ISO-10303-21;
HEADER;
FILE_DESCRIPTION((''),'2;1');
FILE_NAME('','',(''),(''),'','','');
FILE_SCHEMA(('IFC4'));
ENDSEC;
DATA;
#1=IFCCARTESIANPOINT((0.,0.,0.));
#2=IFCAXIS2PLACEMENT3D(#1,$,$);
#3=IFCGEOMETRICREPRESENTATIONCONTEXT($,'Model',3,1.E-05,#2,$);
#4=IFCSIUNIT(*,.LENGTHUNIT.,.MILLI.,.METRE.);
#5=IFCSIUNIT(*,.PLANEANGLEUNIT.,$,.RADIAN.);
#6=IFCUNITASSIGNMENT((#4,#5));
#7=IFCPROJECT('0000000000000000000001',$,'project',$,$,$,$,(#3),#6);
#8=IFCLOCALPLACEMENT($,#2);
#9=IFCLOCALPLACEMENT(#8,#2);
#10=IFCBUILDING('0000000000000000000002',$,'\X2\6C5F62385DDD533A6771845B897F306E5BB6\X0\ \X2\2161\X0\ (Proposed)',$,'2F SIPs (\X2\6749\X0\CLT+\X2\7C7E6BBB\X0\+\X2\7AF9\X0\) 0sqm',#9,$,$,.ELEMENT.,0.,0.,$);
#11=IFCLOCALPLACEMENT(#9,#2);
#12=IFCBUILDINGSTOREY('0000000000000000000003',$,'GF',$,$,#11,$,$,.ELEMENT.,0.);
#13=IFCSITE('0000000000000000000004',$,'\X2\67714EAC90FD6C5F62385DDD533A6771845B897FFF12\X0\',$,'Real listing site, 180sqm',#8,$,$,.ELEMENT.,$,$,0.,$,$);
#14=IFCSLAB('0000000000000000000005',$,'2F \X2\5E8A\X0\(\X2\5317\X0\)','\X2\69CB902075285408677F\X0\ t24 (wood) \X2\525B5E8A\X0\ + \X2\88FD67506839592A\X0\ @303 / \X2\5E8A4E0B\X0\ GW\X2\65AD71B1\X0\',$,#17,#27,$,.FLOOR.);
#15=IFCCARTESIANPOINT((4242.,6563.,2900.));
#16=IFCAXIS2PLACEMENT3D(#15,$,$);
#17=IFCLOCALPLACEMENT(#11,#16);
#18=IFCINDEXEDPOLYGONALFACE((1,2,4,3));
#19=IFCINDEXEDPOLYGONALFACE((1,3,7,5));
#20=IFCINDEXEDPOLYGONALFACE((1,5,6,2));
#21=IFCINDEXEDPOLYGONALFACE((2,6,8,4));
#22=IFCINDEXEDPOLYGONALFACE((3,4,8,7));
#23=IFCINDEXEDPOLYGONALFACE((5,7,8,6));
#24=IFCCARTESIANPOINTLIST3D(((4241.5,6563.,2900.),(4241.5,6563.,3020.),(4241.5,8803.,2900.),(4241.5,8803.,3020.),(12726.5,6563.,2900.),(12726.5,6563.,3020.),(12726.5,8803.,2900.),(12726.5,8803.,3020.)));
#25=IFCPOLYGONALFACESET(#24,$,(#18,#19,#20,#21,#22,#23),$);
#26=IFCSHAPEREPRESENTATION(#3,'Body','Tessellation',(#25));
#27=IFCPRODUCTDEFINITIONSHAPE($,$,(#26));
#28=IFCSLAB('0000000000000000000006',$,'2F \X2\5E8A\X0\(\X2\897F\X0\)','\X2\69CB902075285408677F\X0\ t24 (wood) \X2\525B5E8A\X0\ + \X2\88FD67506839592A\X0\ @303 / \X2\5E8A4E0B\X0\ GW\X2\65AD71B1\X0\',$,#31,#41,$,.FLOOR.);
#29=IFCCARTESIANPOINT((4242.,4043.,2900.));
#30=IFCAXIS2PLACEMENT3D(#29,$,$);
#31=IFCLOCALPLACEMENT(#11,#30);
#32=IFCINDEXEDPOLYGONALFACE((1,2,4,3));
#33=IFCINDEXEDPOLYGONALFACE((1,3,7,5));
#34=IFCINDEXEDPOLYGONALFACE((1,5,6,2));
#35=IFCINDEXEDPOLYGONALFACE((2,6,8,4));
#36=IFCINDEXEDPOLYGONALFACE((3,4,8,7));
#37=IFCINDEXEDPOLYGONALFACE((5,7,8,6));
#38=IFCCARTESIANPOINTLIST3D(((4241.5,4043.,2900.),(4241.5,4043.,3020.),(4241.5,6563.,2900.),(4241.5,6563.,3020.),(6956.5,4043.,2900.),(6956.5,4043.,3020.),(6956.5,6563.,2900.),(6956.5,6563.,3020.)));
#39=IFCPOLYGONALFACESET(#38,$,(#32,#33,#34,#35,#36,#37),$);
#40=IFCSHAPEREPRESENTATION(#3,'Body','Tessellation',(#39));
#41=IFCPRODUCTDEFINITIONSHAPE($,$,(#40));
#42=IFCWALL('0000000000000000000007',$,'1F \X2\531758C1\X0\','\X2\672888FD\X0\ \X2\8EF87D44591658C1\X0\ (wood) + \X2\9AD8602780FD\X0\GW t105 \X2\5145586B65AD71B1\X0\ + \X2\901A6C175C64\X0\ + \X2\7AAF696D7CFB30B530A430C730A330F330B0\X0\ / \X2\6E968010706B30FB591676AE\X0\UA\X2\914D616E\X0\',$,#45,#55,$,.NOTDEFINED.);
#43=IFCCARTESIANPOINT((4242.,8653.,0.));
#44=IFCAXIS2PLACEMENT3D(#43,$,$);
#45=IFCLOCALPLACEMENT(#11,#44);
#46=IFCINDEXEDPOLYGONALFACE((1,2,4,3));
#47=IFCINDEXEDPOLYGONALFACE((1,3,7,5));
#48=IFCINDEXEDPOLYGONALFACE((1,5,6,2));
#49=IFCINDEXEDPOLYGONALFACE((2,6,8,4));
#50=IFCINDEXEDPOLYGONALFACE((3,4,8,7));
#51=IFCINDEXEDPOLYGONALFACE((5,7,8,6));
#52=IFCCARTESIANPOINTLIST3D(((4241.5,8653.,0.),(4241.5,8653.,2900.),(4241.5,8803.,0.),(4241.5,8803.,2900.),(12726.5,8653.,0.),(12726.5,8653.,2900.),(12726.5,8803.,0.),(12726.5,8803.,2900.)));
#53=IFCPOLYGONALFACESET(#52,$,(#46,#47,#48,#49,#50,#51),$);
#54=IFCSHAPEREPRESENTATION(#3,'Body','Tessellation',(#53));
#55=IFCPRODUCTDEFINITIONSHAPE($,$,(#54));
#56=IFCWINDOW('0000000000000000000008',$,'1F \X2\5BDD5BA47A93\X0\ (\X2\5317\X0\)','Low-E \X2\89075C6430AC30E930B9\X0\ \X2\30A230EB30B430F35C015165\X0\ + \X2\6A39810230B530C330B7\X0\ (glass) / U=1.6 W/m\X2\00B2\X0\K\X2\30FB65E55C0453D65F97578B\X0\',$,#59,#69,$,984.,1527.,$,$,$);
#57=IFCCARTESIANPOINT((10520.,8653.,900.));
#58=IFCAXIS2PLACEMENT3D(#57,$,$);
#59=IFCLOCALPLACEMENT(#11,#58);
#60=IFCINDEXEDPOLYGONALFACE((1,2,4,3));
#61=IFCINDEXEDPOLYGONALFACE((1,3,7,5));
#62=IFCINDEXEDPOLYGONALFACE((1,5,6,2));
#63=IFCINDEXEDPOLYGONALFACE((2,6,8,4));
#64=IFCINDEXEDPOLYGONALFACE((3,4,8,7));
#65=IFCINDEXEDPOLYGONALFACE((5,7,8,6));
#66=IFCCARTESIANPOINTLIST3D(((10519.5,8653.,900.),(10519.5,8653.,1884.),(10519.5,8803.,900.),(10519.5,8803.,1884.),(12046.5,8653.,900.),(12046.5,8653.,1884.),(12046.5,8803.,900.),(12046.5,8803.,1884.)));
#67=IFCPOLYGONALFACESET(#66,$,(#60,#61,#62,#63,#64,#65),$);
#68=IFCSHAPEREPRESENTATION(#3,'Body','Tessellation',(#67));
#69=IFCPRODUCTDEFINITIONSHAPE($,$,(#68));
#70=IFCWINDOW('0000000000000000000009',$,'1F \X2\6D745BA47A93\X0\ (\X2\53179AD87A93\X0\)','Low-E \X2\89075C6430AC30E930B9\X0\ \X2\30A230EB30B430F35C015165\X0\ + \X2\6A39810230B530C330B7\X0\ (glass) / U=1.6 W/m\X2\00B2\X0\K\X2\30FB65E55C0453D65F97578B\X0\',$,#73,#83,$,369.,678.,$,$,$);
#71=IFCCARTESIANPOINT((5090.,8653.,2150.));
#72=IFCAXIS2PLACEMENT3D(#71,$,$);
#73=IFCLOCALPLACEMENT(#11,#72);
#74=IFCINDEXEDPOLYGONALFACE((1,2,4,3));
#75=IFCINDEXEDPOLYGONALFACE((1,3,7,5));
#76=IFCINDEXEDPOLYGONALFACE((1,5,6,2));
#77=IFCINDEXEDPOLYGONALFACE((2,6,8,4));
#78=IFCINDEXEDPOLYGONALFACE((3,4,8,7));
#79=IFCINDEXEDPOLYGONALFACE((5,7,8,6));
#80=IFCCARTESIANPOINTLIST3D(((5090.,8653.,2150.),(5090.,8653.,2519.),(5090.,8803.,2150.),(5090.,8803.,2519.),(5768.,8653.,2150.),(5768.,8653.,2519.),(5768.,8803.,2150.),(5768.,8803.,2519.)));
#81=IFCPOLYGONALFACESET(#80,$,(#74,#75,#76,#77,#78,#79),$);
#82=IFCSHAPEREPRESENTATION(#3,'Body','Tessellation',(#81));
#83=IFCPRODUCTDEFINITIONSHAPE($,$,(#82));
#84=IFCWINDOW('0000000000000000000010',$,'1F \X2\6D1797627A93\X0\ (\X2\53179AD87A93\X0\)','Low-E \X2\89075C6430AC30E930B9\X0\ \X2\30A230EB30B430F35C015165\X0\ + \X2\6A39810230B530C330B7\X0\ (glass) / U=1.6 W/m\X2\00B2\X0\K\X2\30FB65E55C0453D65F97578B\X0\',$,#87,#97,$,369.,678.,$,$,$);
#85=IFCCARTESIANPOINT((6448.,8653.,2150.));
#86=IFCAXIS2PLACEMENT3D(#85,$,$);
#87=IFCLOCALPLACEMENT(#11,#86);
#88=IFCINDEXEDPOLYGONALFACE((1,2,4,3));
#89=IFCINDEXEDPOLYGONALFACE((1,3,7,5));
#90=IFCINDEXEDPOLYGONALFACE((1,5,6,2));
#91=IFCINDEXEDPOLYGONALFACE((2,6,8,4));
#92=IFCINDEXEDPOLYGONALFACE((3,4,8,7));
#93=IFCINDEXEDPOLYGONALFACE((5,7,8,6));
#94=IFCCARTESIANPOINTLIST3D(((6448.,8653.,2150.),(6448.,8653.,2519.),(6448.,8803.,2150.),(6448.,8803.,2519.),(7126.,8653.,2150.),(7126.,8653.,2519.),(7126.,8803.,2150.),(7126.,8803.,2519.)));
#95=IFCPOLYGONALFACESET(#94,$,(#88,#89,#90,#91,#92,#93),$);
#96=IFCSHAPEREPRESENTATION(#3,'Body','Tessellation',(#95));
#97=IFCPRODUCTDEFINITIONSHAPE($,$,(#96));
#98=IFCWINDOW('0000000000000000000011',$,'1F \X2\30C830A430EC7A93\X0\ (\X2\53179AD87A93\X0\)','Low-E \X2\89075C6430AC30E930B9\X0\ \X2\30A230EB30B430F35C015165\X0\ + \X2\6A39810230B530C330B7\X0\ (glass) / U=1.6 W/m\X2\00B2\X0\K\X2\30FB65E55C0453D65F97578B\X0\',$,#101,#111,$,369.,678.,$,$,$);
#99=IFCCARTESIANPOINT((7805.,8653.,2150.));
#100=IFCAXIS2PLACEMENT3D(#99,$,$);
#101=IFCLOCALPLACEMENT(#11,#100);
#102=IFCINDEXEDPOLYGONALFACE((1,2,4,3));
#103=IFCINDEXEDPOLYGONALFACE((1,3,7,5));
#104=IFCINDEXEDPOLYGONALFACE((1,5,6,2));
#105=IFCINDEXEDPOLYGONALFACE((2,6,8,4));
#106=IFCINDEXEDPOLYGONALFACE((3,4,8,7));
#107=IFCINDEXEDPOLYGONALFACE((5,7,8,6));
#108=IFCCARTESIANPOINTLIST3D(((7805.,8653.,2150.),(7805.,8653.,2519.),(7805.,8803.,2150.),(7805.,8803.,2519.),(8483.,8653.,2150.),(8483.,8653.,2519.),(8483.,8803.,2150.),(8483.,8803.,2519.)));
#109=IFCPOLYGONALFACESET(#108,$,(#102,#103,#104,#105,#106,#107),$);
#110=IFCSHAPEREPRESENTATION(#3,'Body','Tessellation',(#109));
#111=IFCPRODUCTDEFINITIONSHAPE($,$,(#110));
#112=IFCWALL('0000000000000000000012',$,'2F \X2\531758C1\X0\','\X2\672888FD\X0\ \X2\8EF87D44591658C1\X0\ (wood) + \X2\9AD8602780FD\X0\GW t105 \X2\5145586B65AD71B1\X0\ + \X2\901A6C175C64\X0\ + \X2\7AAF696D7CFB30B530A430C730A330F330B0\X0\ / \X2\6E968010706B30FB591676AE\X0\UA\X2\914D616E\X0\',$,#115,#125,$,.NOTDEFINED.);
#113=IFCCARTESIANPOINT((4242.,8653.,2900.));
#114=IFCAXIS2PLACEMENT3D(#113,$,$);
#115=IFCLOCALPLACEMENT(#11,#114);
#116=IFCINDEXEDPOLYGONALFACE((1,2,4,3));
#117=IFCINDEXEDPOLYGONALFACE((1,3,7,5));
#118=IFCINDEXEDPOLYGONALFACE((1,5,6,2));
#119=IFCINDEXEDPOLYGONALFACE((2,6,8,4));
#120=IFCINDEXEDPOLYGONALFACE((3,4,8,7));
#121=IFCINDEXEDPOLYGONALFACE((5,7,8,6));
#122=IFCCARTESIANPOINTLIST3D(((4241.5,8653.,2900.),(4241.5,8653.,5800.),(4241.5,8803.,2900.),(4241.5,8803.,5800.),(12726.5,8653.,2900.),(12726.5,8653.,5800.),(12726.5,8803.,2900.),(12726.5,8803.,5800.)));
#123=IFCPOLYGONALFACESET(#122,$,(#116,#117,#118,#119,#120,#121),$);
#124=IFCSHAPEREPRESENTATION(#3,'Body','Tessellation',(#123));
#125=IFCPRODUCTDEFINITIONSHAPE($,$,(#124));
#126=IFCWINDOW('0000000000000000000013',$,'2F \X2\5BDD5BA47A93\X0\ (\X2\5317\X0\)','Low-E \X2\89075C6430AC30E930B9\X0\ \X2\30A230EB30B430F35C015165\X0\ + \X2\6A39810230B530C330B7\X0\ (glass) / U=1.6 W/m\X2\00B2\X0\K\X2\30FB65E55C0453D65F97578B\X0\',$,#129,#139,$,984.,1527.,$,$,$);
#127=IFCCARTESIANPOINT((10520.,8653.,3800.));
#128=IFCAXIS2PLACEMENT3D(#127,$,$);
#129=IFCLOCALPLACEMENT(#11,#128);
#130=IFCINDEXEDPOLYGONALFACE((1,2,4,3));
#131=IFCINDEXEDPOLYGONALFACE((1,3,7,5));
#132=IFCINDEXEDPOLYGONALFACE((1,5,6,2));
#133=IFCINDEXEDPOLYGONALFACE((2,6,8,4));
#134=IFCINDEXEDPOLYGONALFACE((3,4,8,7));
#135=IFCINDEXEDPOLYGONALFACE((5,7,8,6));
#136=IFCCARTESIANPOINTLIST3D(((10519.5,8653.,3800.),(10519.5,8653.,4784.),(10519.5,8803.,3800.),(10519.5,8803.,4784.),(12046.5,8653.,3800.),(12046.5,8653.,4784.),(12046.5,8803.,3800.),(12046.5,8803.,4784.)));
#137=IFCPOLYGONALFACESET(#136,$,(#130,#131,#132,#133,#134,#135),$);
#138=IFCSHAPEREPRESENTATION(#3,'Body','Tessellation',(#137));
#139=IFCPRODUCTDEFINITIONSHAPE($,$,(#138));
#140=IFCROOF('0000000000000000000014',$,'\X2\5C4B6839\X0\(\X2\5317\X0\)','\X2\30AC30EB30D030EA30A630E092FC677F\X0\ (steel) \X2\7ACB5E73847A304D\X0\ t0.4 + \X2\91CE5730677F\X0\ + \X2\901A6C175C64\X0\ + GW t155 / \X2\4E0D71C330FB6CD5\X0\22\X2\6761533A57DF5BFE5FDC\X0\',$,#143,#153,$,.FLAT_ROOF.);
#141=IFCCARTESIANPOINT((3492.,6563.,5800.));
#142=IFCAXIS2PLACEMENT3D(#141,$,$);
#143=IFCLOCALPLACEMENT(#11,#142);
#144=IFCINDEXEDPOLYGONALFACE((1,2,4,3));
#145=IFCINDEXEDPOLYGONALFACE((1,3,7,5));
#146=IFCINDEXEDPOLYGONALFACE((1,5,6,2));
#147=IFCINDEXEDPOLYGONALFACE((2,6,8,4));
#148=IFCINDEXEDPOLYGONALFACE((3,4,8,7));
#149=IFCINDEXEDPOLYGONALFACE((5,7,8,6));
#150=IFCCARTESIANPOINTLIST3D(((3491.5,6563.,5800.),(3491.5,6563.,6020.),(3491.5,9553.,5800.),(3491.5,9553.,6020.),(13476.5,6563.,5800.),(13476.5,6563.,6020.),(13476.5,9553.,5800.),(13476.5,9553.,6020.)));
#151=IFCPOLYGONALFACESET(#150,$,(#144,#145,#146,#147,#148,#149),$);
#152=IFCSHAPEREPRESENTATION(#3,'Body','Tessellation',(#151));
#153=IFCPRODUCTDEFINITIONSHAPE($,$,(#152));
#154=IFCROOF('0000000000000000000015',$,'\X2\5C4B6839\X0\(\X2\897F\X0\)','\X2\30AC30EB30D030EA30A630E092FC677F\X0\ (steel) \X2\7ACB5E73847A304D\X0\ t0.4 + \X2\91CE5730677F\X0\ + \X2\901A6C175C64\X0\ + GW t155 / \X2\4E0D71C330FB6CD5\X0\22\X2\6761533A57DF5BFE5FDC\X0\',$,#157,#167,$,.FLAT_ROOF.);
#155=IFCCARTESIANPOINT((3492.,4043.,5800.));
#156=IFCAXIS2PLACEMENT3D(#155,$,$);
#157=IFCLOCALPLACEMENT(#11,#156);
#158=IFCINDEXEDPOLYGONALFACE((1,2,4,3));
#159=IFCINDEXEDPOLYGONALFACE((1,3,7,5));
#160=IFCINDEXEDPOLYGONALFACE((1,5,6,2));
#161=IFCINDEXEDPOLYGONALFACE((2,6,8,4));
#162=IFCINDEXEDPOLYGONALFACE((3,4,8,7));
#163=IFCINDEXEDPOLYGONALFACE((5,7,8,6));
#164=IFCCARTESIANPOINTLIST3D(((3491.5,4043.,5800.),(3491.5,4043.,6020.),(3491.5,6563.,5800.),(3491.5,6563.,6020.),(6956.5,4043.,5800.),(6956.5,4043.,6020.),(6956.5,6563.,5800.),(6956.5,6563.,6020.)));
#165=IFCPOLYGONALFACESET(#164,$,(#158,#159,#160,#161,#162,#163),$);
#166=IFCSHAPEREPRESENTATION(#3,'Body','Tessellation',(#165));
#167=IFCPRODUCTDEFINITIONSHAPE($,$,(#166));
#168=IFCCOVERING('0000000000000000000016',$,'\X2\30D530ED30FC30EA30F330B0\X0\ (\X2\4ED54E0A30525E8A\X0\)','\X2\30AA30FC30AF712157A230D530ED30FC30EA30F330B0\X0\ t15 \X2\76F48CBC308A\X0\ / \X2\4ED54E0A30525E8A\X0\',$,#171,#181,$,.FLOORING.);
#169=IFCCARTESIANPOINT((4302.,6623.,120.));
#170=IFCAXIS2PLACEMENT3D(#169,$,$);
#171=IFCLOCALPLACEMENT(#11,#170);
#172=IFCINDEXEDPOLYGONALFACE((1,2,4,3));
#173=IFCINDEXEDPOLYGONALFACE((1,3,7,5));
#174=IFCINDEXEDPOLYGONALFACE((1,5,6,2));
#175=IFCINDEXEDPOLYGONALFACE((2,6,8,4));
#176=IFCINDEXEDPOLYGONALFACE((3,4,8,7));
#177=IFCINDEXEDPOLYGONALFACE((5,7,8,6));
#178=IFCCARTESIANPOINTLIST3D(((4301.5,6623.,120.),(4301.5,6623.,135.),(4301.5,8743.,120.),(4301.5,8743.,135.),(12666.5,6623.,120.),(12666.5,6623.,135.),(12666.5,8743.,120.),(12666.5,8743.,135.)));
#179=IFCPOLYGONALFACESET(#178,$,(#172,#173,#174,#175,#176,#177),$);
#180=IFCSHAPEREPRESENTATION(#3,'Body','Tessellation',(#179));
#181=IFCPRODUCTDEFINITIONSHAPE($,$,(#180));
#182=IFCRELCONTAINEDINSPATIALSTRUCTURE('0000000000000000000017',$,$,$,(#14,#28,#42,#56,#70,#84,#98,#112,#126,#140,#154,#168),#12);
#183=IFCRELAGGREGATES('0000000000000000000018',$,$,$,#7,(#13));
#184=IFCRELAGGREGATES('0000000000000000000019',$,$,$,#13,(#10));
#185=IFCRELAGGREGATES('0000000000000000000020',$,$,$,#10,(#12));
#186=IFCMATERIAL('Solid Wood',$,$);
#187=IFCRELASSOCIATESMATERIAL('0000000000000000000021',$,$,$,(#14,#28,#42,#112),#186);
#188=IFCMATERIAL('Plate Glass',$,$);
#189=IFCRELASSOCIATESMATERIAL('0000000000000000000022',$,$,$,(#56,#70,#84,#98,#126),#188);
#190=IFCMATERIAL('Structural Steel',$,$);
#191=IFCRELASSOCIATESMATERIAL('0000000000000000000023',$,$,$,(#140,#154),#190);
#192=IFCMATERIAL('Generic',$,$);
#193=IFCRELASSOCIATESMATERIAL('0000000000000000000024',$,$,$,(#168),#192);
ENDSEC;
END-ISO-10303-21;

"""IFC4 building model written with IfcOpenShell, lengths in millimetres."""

from ifc_helpers import new_model, si_unit, frame, frame_2d, origin, place, context, project, spatial, rectangle, extrude, material, element, fill, save


model = new_model("IFC4")

# Units and contexts
model_context = context("Model", 3, precision=1e-05, world=origin())
ifc_project = project(units=[si_unit("LENGTHUNIT", "METRE", prefix="MILLI"), si_unit("PLANEANGLEUNIT", "RADIAN")], contexts=[model_context])

# Site, building, storey
site_placement = place(None, origin())
site = spatial("IfcSite", under=ifc_project, at=site_placement, Name="東京都江戸川区東葛西２", ObjectType="Real listing site, 180sqm", CompositionType="ELEMENT", RefElevation=0.0)
building_placement = place(site_placement, origin())
building = spatial("IfcBuilding", under=site, at=building_placement, Name="江戸川区東葛西の家 Ⅱ (Proposed)", ObjectType="2F SIPs (杉CLT+籾殻+竹) 0sqm", CompositionType="ELEMENT", ElevationOfRefHeight=0.0, ElevationOfTerrain=0.0)
storey_placement = place(building_placement, origin())
storey = spatial("IfcBuildingStorey", under=building, at=storey_placement, Name="GF", CompositionType="ELEMENT", Elevation=0.0)

# Slabs
ifc_material_1 = material(Name="Solid Wood")
slab_1_placement = place(storey_placement, frame((4242.0, 6563.0, 2900.0)))
element("IfcSlab", 1, at=slab_1_placement, inside=storey, material=ifc_material_1, Name="2F 床(北)", Description="構造用合板 t24 (wood) 剛床 + 製材根太 @303 / 床下 GW断熱", PredefinedType="FLOOR", context=model_context, shape_type="SweptSolid", body=[
    extrude(rectangle(XDim=8485.0, YDim=2240.0, at=frame_2d((4242.0, 1120.0))), frame((4242.0, 6563.0, 2900.0)), (0.0, 0.0, 1.0), 120.0),
])
slab_2_placement = place(storey_placement, frame((4242.0, 4043.0, 2900.0)))
element("IfcSlab", 2, at=slab_2_placement, inside=storey, material=ifc_material_1, Name="2F 床(西)", Description="構造用合板 t24 (wood) 剛床 + 製材根太 @303 / 床下 GW断熱", PredefinedType="FLOOR", context=model_context, shape_type="SweptSolid", body=[
    extrude(rectangle(XDim=2715.0, YDim=2520.0, at=frame_2d((1357.0, 1260.0))), frame((4242.0, 4043.0, 2900.0)), (0.0, 0.0, 1.0), 120.0),
])

# Wall, openings, windows
wall_1_placement = place(storey_placement, frame((4242.0, 8653.0, 0.0)))
wall_1 = element("IfcWall", 3, at=wall_1_placement, inside=storey, material=ifc_material_1, Name="1F 北壁", Description="木製 軸組外壁 (wood) + 高性能GW t105 充填断熱 + 通気層 + 窯業系サイディング / 準耐火・外皮UA配慮", PredefinedType="NOTDEFINED", context=model_context, shape_type="SweptSolid", body=[
    extrude(rectangle(XDim=8485.0, YDim=150.0, at=frame_2d((4242.0, 75.0))), frame((4242.0, 8653.0, 0.0)), (0.0, 0.0, 1.0), 2900.0),
])
opening_1_placement = place(storey_placement, frame((10520.0, 8653.0, 900.0)))
opening_1 = element("IfcOpeningElement", 4, at=opening_1_placement, cuts=wall_1, PredefinedType="NOTDEFINED", context=model_context, shape_type="SweptSolid", body=[
    extrude(rectangle(XDim=1527.0, YDim=150.0, at=frame_2d((763.0, 75.0))), frame((10520.0, 8653.0, 900.0)), (0.0, 0.0, 1.0), 984.0),
])
opening_2_placement = place(storey_placement, frame((5090.0, 8653.0, 2150.0)))
opening_2 = element("IfcOpeningElement", 5, at=opening_2_placement, cuts=wall_1, PredefinedType="NOTDEFINED", context=model_context, shape_type="SweptSolid", body=[
    extrude(rectangle(XDim=678.0, YDim=150.0, at=frame_2d((339.0, 75.0))), frame((5090.0, 8653.0, 2150.0)), (0.0, 0.0, 1.0), 369.0),
])
opening_3_placement = place(storey_placement, frame((6448.0, 8653.0, 2150.0)))
opening_3 = element("IfcOpeningElement", 6, at=opening_3_placement, cuts=wall_1, PredefinedType="NOTDEFINED", context=model_context, shape_type="SweptSolid", body=[
    extrude(rectangle(XDim=678.0, YDim=150.0, at=frame_2d((339.0, 75.0))), frame((6448.0, 8653.0, 2150.0)), (0.0, 0.0, 1.0), 369.0),
])
opening_4_placement = place(storey_placement, frame((7805.0, 8653.0, 2150.0)))
opening_4 = element("IfcOpeningElement", 7, at=opening_4_placement, cuts=wall_1, PredefinedType="NOTDEFINED", context=model_context, shape_type="SweptSolid", body=[
    extrude(rectangle(XDim=678.0, YDim=150.0, at=frame_2d((339.0, 75.0))), frame((7805.0, 8653.0, 2150.0)), (0.0, 0.0, 1.0), 369.0),
])
ifc_material_2 = material(Name="Plate Glass")
window_1_placement = place(storey_placement, frame((10520.0, 8653.0, 900.0)))
window_1 = element("IfcWindow", 8, at=window_1_placement, inside=storey, material=ifc_material_2, Name="1F 寝室窓 (北)", Description="Low-E 複層ガラス アルゴン封入 + 樹脂サッシ (glass) / U=1.6 W/m²K・日射取得型", OverallHeight=984.0, OverallWidth=1527.0, context=model_context, shape_type="SweptSolid", body=[
    extrude(rectangle(XDim=1527.0, YDim=150.0, at=frame_2d((763.0, 75.0))), frame((10520.0, 8653.0, 900.0)), (0.0, 0.0, 1.0), 984.0),
])
fill(opening_1, window_1)
window_2_placement = place(storey_placement, frame((5090.0, 8653.0, 2150.0)))
window_2 = element("IfcWindow", 9, at=window_2_placement, inside=storey, material=ifc_material_2, Name="1F 浴室窓 (北高窓)", Description="Low-E 複層ガラス アルゴン封入 + 樹脂サッシ (glass) / U=1.6 W/m²K・日射取得型", OverallHeight=369.0, OverallWidth=678.0, context=model_context, shape_type="SweptSolid", body=[
    extrude(rectangle(XDim=678.0, YDim=150.0, at=frame_2d((339.0, 75.0))), frame((5090.0, 8653.0, 2150.0)), (0.0, 0.0, 1.0), 369.0),
])
fill(opening_2, window_2)
window_3_placement = place(storey_placement, frame((6448.0, 8653.0, 2150.0)))
window_3 = element("IfcWindow", 10, at=window_3_placement, inside=storey, material=ifc_material_2, Name="1F 洗面窓 (北高窓)", Description="Low-E 複層ガラス アルゴン封入 + 樹脂サッシ (glass) / U=1.6 W/m²K・日射取得型", OverallHeight=369.0, OverallWidth=678.0, context=model_context, shape_type="SweptSolid", body=[
    extrude(rectangle(XDim=678.0, YDim=150.0, at=frame_2d((339.0, 75.0))), frame((6448.0, 8653.0, 2150.0)), (0.0, 0.0, 1.0), 369.0),
])
fill(opening_3, window_3)
window_4_placement = place(storey_placement, frame((7805.0, 8653.0, 2150.0)))
window_4 = element("IfcWindow", 11, at=window_4_placement, inside=storey, material=ifc_material_2, Name="1F トイレ窓 (北高窓)", Description="Low-E 複層ガラス アルゴン封入 + 樹脂サッシ (glass) / U=1.6 W/m²K・日射取得型", OverallHeight=369.0, OverallWidth=678.0, context=model_context, shape_type="SweptSolid", body=[
    extrude(rectangle(XDim=678.0, YDim=150.0, at=frame_2d((339.0, 75.0))), frame((7805.0, 8653.0, 2150.0)), (0.0, 0.0, 1.0), 369.0),
])
fill(opening_4, window_4)

# Wall, opening, window
wall_2_placement = place(storey_placement, frame((4242.0, 8653.0, 2900.0)))
wall_2 = element("IfcWall", 12, at=wall_2_placement, inside=storey, material=ifc_material_1, Name="2F 北壁", Description="木製 軸組外壁 (wood) + 高性能GW t105 充填断熱 + 通気層 + 窯業系サイディング / 準耐火・外皮UA配慮", PredefinedType="NOTDEFINED", context=model_context, shape_type="SweptSolid", body=[
    extrude(rectangle(XDim=8485.0, YDim=150.0, at=frame_2d((4242.0, 75.0))), frame((4242.0, 8653.0, 2900.0)), (0.0, 0.0, 1.0), 2900.0),
])
opening_5_placement = place(storey_placement, frame((10520.0, 8653.0, 3800.0)))
opening_5 = element("IfcOpeningElement", 13, at=opening_5_placement, cuts=wall_2, PredefinedType="NOTDEFINED", context=model_context, shape_type="SweptSolid", body=[
    extrude(rectangle(XDim=1527.0, YDim=150.0, at=frame_2d((763.0, 75.0))), frame((10520.0, 8653.0, 3800.0)), (0.0, 0.0, 1.0), 984.0),
])
window_5_placement = place(storey_placement, frame((10520.0, 8653.0, 3800.0)))
window_5 = element("IfcWindow", 14, at=window_5_placement, inside=storey, material=ifc_material_2, Name="2F 寝室窓 (北)", Description="Low-E 複層ガラス アルゴン封入 + 樹脂サッシ (glass) / U=1.6 W/m²K・日射取得型", OverallHeight=984.0, OverallWidth=1527.0, context=model_context, shape_type="SweptSolid", body=[
    extrude(rectangle(XDim=1527.0, YDim=150.0, at=frame_2d((763.0, 75.0))), frame((10520.0, 8653.0, 3800.0)), (0.0, 0.0, 1.0), 984.0),
])
fill(opening_5, window_5)

# Roofs
ifc_material_3 = material(Name="Structural Steel")
for number, where, name in (
    (15, (3492.0, 6563.0, 5800.0), "屋根(北)"),
):
    element("IfcRoof", number, at=place(storey_placement, frame(where)), inside=storey, material=ifc_material_3, Name=name, Description="ガルバリウム鋼板 (steel) 立平葺き t0.4 + 野地板 + 通気層 + GW t155 / 不燃・法22条区域対応", PredefinedType="FLAT_ROOF", context=model_context, shape_type="SweptSolid", body=[
        extrude(rectangle(XDim=9985.0, YDim=2990.0, at=frame_2d((4992.0, 1495.0))), frame((3492.0, 6563.0, 5800.0)), (0.0, 0.0, 1.0), 220.0),
    ])
roof_placement = place(storey_placement, frame((3492.0, 4043.0, 5800.0)))
element("IfcRoof", 16, at=roof_placement, inside=storey, material=ifc_material_3, Name="屋根(西)", Description="ガルバリウム鋼板 (steel) 立平葺き t0.4 + 野地板 + 通気層 + GW t155 / 不燃・法22条区域対応", PredefinedType="FLAT_ROOF", context=model_context, shape_type="SweptSolid", body=[
    extrude(rectangle(XDim=3465.0, YDim=2520.0, at=frame_2d((1732.0, 1260.0))), frame((3492.0, 4043.0, 5800.0)), (0.0, 0.0, 1.0), 220.0),
])

# Covering
ifc_material_4 = material(Name="Generic")
covering_1_placement = place(storey_placement, frame((4302.0, 6623.0, 120.0)))
element("IfcCovering", 17, at=covering_1_placement, inside=storey, material=ifc_material_4, Name="フローリング (仕上げ床)", Description="オーク無垢フローリング t15 直貼り / 仕上げ床", PredefinedType="FLOORING", context=model_context, shape_type="SweptSolid", body=[
    extrude(rectangle(XDim=8365.0, YDim=2120.0, at=frame_2d((4182.0, 1060.0))), frame((4302.0, 6623.0, 120.0)), (0.0, 0.0, 1.0), 15.0),
])

save(model, "model.ifc")
